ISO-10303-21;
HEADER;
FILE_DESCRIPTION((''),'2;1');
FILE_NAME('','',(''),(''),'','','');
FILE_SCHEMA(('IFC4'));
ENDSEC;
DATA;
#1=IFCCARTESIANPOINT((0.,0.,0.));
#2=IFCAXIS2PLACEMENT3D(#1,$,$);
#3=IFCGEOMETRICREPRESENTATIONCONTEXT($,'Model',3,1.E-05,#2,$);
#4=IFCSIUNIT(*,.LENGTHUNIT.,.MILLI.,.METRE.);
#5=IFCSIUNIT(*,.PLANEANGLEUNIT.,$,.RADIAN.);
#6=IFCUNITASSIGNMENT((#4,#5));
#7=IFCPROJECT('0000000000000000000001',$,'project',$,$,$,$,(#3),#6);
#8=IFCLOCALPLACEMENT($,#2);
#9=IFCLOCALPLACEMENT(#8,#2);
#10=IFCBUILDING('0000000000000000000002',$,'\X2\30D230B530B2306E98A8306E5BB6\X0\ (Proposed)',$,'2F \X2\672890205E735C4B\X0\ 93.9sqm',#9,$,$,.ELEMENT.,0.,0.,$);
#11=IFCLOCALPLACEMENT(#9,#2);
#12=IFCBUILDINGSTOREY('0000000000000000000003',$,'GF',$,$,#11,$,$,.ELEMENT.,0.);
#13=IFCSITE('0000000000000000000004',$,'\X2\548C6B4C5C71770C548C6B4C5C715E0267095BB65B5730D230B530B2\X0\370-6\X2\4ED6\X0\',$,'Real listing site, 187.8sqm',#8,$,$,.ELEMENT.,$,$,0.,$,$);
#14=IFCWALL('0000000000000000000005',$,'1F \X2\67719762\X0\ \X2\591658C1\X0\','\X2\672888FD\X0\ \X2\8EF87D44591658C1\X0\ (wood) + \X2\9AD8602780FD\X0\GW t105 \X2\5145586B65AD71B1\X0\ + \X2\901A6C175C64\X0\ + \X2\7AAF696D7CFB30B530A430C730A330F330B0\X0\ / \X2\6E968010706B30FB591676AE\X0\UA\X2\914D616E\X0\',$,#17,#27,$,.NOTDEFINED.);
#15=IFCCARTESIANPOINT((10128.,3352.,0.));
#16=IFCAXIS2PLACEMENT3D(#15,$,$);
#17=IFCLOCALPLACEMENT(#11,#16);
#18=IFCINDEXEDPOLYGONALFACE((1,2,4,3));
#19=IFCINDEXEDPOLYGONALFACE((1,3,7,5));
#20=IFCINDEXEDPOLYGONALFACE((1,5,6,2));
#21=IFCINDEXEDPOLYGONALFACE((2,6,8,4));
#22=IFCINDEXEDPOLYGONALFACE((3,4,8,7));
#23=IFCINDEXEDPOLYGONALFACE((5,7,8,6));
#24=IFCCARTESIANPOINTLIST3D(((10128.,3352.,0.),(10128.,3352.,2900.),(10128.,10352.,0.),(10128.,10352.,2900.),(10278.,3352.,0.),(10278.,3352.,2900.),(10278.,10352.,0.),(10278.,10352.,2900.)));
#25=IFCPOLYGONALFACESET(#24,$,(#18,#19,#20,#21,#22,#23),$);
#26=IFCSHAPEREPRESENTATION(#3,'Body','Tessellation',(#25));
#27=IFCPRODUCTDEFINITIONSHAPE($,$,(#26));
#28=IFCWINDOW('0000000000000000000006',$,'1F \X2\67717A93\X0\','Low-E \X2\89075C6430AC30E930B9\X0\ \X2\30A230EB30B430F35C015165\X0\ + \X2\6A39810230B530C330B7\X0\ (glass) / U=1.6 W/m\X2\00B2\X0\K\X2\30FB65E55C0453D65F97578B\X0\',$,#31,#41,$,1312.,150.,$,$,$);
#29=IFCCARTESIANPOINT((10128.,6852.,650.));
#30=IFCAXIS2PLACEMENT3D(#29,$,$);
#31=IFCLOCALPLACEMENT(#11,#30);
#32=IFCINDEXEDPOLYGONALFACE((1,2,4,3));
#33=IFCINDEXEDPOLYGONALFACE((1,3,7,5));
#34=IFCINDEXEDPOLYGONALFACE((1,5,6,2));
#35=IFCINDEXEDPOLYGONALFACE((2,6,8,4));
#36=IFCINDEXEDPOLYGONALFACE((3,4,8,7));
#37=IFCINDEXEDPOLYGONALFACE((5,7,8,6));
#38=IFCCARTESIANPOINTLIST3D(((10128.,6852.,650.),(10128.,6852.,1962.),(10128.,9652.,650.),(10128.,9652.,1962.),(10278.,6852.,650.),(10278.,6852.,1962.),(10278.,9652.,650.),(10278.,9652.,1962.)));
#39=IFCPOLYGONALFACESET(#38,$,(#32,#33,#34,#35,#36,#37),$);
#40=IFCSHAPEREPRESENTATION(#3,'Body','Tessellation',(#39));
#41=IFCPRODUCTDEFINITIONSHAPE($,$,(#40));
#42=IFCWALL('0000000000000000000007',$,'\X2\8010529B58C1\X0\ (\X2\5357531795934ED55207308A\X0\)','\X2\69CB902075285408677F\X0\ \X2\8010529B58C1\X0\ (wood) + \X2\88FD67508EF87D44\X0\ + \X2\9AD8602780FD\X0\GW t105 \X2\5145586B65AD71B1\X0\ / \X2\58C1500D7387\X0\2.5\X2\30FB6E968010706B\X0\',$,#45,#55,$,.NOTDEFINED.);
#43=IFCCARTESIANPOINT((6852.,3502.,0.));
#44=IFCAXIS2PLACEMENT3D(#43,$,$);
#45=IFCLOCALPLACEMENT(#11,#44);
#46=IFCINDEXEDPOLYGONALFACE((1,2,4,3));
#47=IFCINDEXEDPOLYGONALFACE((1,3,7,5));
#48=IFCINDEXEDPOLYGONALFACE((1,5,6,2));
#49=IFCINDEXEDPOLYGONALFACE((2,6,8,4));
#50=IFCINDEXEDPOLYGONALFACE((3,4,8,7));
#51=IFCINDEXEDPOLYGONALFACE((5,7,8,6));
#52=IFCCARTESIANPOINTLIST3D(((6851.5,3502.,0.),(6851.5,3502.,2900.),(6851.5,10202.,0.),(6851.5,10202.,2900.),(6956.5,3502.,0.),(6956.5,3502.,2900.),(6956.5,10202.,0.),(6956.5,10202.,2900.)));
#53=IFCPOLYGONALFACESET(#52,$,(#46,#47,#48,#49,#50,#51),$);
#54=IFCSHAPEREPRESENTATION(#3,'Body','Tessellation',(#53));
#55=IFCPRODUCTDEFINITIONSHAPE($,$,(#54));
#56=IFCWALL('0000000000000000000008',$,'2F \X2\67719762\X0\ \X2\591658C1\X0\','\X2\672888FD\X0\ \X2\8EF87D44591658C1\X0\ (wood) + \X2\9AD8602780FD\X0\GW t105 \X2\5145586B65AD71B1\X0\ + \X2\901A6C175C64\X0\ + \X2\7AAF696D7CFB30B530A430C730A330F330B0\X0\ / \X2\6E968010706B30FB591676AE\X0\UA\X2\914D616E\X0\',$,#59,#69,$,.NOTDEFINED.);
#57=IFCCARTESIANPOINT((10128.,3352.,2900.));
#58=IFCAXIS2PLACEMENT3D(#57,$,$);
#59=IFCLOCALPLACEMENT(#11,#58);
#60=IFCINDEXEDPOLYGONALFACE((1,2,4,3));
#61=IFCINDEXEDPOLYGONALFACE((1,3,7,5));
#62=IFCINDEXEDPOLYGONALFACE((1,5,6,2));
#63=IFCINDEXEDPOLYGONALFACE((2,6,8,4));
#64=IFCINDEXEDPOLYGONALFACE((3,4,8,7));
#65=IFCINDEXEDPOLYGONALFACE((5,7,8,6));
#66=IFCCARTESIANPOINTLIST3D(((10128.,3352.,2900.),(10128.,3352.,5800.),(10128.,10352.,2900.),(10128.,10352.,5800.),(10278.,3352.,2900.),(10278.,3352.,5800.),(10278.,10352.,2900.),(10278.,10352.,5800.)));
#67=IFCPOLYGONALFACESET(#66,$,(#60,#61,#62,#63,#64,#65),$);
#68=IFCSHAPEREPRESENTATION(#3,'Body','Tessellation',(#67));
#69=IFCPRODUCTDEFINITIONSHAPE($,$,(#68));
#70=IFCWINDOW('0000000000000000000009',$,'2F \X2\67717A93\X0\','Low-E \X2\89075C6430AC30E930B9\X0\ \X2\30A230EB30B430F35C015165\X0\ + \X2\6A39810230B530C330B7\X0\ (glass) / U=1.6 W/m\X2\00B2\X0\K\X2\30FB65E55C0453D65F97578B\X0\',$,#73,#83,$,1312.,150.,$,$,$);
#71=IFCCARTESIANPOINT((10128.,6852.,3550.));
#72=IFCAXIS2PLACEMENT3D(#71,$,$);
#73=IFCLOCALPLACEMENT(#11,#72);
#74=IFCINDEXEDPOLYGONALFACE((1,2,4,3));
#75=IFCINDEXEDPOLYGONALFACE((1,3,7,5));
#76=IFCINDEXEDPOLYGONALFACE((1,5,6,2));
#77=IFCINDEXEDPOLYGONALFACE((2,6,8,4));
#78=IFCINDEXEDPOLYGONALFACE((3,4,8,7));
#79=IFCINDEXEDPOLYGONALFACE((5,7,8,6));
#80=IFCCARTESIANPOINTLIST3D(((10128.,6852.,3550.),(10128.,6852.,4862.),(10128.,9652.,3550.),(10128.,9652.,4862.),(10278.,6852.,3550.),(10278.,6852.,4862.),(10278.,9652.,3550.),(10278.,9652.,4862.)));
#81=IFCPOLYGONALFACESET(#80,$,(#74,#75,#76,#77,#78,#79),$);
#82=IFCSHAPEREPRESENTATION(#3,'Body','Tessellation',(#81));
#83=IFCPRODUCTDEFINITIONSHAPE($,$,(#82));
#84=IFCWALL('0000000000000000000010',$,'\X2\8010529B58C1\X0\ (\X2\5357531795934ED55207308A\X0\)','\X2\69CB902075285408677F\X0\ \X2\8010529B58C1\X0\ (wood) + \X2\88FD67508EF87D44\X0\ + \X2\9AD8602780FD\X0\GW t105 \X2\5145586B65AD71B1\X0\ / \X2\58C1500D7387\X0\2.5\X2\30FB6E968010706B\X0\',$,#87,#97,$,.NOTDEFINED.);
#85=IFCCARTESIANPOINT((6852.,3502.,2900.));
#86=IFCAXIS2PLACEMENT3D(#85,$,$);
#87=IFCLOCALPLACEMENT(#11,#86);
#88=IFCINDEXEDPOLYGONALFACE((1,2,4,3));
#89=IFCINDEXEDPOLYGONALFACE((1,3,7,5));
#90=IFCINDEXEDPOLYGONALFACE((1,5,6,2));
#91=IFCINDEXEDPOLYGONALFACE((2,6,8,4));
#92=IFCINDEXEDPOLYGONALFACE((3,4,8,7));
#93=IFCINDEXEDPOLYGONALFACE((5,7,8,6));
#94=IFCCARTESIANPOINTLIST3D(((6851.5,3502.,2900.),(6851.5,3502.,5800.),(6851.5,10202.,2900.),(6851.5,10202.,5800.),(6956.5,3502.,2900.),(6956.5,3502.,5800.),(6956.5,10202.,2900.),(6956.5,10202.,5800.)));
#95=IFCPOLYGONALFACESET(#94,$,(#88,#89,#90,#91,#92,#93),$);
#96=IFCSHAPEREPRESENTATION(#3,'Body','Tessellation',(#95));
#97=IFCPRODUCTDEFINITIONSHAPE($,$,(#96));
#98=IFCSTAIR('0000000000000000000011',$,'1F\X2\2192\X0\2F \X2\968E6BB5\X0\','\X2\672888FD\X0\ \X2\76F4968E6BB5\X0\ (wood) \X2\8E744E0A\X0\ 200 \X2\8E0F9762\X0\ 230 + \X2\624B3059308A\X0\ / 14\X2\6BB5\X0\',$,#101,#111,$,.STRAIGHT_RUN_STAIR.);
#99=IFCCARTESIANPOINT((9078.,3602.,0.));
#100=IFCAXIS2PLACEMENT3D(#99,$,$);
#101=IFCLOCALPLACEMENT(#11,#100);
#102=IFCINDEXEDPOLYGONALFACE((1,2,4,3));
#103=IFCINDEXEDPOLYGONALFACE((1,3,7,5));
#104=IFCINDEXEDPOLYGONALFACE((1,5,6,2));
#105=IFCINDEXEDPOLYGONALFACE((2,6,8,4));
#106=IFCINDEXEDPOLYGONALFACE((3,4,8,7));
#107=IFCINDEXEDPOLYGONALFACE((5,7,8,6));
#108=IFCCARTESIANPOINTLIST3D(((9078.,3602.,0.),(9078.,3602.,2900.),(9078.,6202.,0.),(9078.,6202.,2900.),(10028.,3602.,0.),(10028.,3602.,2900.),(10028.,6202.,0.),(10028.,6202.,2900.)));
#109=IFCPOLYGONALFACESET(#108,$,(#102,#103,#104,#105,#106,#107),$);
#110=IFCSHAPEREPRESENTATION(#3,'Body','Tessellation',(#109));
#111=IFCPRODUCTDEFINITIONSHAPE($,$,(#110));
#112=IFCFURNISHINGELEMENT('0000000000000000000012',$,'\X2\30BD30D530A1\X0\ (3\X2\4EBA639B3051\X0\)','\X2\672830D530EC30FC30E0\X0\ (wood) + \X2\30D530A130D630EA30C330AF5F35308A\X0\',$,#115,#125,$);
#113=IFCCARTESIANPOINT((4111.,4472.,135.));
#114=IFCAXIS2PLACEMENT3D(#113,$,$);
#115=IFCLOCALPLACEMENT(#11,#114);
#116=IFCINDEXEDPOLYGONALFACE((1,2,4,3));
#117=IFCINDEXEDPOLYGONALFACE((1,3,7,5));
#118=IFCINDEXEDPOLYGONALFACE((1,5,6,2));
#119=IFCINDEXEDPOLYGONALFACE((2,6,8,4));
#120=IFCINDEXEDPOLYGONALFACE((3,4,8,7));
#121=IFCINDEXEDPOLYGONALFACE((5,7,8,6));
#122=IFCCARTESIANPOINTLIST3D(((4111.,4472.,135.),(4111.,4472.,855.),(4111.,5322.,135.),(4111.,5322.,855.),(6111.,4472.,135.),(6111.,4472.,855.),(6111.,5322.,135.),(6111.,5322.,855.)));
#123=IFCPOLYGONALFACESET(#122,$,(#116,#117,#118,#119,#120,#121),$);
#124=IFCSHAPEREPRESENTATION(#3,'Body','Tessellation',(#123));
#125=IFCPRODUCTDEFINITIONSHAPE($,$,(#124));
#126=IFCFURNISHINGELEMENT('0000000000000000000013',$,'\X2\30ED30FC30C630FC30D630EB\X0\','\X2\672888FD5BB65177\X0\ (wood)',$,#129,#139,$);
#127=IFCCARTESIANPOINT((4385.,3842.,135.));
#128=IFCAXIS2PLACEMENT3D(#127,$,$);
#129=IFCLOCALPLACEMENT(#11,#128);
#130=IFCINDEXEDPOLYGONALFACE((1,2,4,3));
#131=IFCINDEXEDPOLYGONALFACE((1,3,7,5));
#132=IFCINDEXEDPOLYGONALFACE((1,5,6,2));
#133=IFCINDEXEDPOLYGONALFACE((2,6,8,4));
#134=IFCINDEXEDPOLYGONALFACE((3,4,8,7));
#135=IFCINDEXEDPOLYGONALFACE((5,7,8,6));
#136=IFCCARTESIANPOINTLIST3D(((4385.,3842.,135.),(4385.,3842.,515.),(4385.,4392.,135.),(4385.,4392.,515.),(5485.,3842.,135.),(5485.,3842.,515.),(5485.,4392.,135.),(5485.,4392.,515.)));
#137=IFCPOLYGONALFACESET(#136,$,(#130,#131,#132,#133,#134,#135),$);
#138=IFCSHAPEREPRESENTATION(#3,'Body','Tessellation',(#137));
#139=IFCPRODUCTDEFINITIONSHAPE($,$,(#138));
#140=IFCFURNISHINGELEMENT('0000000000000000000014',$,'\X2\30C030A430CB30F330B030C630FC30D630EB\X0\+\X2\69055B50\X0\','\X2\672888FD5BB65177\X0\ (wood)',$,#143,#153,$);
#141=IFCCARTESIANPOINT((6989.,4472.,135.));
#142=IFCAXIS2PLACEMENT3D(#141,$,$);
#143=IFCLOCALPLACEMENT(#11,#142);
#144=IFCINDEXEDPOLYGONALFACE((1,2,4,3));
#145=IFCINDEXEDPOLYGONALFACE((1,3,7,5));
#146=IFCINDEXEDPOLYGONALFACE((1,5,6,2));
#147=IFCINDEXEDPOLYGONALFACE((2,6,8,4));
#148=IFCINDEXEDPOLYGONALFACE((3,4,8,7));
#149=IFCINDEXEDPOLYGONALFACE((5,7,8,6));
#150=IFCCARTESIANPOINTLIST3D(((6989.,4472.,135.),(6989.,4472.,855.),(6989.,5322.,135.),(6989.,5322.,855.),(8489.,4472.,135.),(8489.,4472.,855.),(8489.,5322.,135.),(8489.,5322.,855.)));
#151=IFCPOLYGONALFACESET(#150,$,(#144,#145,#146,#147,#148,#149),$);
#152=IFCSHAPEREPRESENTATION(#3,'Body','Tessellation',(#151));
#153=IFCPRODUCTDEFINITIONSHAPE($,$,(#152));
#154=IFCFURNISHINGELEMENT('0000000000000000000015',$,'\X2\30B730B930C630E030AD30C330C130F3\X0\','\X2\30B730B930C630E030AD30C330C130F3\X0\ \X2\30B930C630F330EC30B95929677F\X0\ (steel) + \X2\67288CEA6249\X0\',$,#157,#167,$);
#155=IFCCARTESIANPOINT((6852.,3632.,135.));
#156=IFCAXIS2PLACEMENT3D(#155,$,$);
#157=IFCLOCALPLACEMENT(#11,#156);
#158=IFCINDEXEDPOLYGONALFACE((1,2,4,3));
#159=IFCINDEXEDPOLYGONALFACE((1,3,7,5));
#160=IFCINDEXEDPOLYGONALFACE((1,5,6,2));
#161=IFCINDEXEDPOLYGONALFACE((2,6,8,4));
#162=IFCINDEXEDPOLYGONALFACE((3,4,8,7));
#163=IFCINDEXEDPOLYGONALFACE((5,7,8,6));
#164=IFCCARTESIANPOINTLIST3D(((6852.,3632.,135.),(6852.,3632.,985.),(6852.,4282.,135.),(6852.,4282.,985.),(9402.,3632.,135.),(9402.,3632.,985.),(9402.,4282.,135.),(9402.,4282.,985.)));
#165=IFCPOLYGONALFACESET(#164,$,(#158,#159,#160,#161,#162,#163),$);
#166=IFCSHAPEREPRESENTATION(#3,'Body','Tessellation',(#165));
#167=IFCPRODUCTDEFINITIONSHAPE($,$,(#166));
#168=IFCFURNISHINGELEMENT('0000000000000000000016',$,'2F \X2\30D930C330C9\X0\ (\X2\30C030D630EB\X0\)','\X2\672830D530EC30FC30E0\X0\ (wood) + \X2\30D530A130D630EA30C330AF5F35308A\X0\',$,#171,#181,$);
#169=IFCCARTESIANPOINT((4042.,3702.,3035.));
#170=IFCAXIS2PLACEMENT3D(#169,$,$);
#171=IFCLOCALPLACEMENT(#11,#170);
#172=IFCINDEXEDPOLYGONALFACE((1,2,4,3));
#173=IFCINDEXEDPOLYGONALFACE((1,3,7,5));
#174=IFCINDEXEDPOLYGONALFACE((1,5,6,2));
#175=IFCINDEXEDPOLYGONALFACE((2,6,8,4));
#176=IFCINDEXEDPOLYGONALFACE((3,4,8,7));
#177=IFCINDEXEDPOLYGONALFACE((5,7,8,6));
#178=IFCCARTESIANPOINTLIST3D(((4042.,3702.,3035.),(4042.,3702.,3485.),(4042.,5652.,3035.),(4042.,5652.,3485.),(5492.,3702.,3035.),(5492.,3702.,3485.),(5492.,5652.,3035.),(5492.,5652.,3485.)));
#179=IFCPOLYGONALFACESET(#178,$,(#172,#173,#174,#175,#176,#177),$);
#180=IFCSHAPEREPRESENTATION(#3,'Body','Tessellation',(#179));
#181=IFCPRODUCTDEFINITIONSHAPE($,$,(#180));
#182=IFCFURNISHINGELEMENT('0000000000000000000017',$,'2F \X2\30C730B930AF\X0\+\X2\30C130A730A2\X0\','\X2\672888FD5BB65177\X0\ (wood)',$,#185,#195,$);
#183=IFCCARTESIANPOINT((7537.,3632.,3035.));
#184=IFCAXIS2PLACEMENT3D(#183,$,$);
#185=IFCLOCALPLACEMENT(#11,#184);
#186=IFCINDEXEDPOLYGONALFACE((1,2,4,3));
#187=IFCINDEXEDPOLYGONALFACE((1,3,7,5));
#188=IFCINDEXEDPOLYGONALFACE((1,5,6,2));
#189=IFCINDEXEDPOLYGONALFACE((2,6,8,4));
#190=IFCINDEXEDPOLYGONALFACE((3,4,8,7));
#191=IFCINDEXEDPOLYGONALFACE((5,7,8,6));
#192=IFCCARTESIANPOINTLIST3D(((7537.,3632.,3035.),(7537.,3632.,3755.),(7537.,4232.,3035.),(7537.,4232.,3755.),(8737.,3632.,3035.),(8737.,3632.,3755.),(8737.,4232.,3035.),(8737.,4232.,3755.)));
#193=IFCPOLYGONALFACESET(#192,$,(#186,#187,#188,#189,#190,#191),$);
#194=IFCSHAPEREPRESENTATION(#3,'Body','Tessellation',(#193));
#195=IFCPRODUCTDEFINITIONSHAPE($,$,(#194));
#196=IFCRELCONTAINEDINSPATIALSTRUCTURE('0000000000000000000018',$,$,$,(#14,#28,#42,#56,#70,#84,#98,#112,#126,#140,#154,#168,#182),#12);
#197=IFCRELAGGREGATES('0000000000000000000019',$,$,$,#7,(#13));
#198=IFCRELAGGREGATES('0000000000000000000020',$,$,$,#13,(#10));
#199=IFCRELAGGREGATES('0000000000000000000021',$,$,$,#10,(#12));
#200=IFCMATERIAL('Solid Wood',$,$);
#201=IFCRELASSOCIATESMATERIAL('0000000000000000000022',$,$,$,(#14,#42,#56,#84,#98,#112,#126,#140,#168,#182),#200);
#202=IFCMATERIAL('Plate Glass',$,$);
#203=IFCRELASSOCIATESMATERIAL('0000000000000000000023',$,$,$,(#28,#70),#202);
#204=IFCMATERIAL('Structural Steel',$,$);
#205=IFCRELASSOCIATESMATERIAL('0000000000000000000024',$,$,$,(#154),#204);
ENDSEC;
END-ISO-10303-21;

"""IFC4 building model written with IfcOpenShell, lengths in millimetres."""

from ifc_helpers import new_model, si_unit, frame, frame_2d, origin, place, context, project, spatial, rectangle, extrude, material, element, fill, save


model = new_model("IFC4")

# Units and contexts
model_context = context("Model", 3, precision=1e-05, world=origin())
ifc_project = project(units=[si_unit("LENGTHUNIT", "METRE", prefix="MILLI"), si_unit("PLANEANGLEUNIT", "RADIAN")], contexts=[model_context])

# Site, building, storey
site_placement = place(None, origin())
site = spatial("IfcSite", under=ifc_project, at=site_placement, Name="和歌山県和歌山市有家字ヒサゲ370-6他", ObjectType="Real listing site, 187.8sqm", CompositionType="ELEMENT", RefElevation=0.0)
building_placement = place(site_placement, origin())
building = spatial("IfcBuilding", under=site, at=building_placement, Name="ヒサゲの風の家 (Proposed)", ObjectType="2F 木造平屋 93.9sqm", CompositionType="ELEMENT", ElevationOfRefHeight=0.0, ElevationOfTerrain=0.0)
storey_placement = place(building_placement, origin())
storey = spatial("IfcBuildingStorey", under=building, at=storey_placement, Name="GF", CompositionType="ELEMENT", Elevation=0.0)

# Wall, opening, window
ifc_material_1 = material(Name="Solid Wood")
wall_1_placement = place(storey_placement, frame((10128.0, 3352.0, 0.0)))
wall_1 = element("IfcWall", 1, at=wall_1_placement, inside=storey, material=ifc_material_1, Name="1F 東面 外壁", Description="木製 軸組外壁 (wood) + 高性能GW t105 充填断熱 + 通気層 + 窯業系サイディング / 準耐火・外皮UA配慮", PredefinedType="NOTDEFINED", context=model_context, shape_type="SweptSolid", body=[
    extrude(rectangle(XDim=150.0, YDim=7000.0, at=frame_2d((75.0, 3500.0))), frame((10128.0, 3352.0, 0.0)), (0.0, 0.0, 1.0), 2900.0),
])
opening_1_placement = place(storey_placement, frame((10128.0, 6852.0, 650.0)))
opening_1 = element("IfcOpeningElement", 2, at=opening_1_placement, cuts=wall_1, PredefinedType="NOTDEFINED", context=model_context, shape_type="SweptSolid", body=[
    extrude(rectangle(XDim=150.0, YDim=2800.0, at=frame_2d((75.0, 1400.0))), frame((10128.0, 6852.0, 650.0)), (0.0, 0.0, 1.0), 1312.0),
])
ifc_material_2 = material(Name="Plate Glass")
window_1_placement = place(storey_placement, frame((10128.0, 6852.0, 650.0)))
window_1 = element("IfcWindow", 3, at=window_1_placement, inside=storey, material=ifc_material_2, Name="1F 東窓", Description="Low-E 複層ガラス アルゴン封入 + 樹脂サッシ (glass) / U=1.6 W/m²K・日射取得型", OverallHeight=1312.0, OverallWidth=150.0, context=model_context, shape_type="SweptSolid", body=[
    extrude(rectangle(XDim=150.0, YDim=2800.0, at=frame_2d((75.0, 1400.0))), frame((10128.0, 6852.0, 650.0)), (0.0, 0.0, 1.0), 1312.0),
])
fill(opening_1, window_1)

# Wall
wall_2_placement = place(storey_placement, frame((6852.0, 3502.0, 0.0)))
element("IfcWall", 4, at=wall_2_placement, inside=storey, material=ifc_material_1, Name="耐力壁 (南北間仕切り)", Description="構造用合板 耐力壁 (wood) + 製材軸組 + 高性能GW t105 充填断熱 / 壁倍率2.5・準耐火", PredefinedType="NOTDEFINED", context=model_context, shape_type="SweptSolid", body=[
    extrude(rectangle(XDim=105.0, YDim=6700.0, at=frame_2d((52.0, 3350.0))), frame((6852.0, 3502.0, 0.0)), (0.0, 0.0, 1.0), 2900.0),
])

# Wall, opening, window
wall_3_placement = place(storey_placement, frame((10128.0, 3352.0, 2900.0)))
wall_3 = element("IfcWall", 5, at=wall_3_placement, inside=storey, material=ifc_material_1, Name="2F 東面 外壁", Description="木製 軸組外壁 (wood) + 高性能GW t105 充填断熱 + 通気層 + 窯業系サイディング / 準耐火・外皮UA配慮", PredefinedType="NOTDEFINED", context=model_context, shape_type="SweptSolid", body=[
    extrude(rectangle(XDim=150.0, YDim=7000.0, at=frame_2d((75.0, 3500.0))), frame((10128.0, 3352.0, 2900.0)), (0.0, 0.0, 1.0), 2900.0),
])
opening_2_placement = place(storey_placement, frame((10128.0, 6852.0, 3550.0)))
opening_2 = element("IfcOpeningElement", 6, at=opening_2_placement, cuts=wall_3, PredefinedType="NOTDEFINED", context=model_context, shape_type="SweptSolid", body=[
    extrude(rectangle(XDim=150.0, YDim=2800.0, at=frame_2d((75.0, 1400.0))), frame((10128.0, 6852.0, 3550.0)), (0.0, 0.0, 1.0), 1312.0),
])
window_2_placement = place(storey_placement, frame((10128.0, 6852.0, 3550.0)))
window_2 = element("IfcWindow", 7, at=window_2_placement, inside=storey, material=ifc_material_2, Name="2F 東窓", Description="Low-E 複層ガラス アルゴン封入 + 樹脂サッシ (glass) / U=1.6 W/m²K・日射取得型", OverallHeight=1312.0, OverallWidth=150.0, context=model_context, shape_type="SweptSolid", body=[
    extrude(rectangle(XDim=150.0, YDim=2800.0, at=frame_2d((75.0, 1400.0))), frame((10128.0, 6852.0, 3550.0)), (0.0, 0.0, 1.0), 1312.0),
])
fill(opening_2, window_2)

# Wall
wall_4_placement = place(storey_placement, frame((6852.0, 3502.0, 2900.0)))
element("IfcWall", 8, at=wall_4_placement, inside=storey, material=ifc_material_1, Name="耐力壁 (南北間仕切り)", Description="構造用合板 耐力壁 (wood) + 製材軸組 + 高性能GW t105 充填断熱 / 壁倍率2.5・準耐火", PredefinedType="NOTDEFINED", context=model_context, shape_type="SweptSolid", body=[
    extrude(rectangle(XDim=105.0, YDim=6700.0, at=frame_2d((52.0, 3350.0))), frame((6852.0, 3502.0, 2900.0)), (0.0, 0.0, 1.0), 2900.0),
])

# Stair
stair_placement = place(storey_placement, frame((9078.0, 3602.0, 0.0)))
element("IfcStair", 9, at=stair_placement, inside=storey, material=ifc_material_1, Name="1F→2F 階段", Description="木製 直階段 (wood) 蹴上 200 踏面 230 + 手すり / 14段", PredefinedType="STRAIGHT_RUN_STAIR", context=model_context, shape_type="SweptSolid", body=[
    extrude(rectangle(XDim=950.0, YDim=2600.0, at=frame_2d((475.0, 1300.0))), frame((9078.0, 3602.0, 0.0)), (0.0, 0.0, 1.0), 2900.0),
])

# Furnishing elements
furnishing_1_placement = place(storey_placement, frame((4111.0, 4472.0, 135.0)))
element("IfcFurnishingElement", 10, at=furnishing_1_placement, inside=storey, material=ifc_material_1, Name="ソファ (3人掛け)", Description="木フレーム (wood) + ファブリック張り", context=model_context, shape_type="SweptSolid", body=[
    extrude(rectangle(XDim=2000.0, YDim=850.0, at=frame_2d((1000.0, 425.0))), frame((4111.0, 4472.0, 135.0)), (0.0, 0.0, 1.0), 720.0),
])
furnishing_2_placement = place(storey_placement, frame((4385.0, 3842.0, 135.0)))
element("IfcFurnishingElement", 11, at=furnishing_2_placement, inside=storey, material=ifc_material_1, Name="ローテーブル", Description="木製家具 (wood)", context=model_context, shape_type="SweptSolid", body=[
    extrude(rectangle(XDim=1100.0, YDim=550.0, at=frame_2d((550.0, 275.0))), frame((4385.0, 3842.0, 135.0)), (0.0, 0.0, 1.0), 380.0),
])
furnishing_3_placement = place(storey_placement, frame((6989.0, 4472.0, 135.0)))
element("IfcFurnishingElement", 12, at=furnishing_3_placement, inside=storey, material=ifc_material_1, Name="ダイニングテーブル+椅子", Description="木製家具 (wood)", context=model_context, shape_type="SweptSolid", body=[
    extrude(rectangle(XDim=1500.0, YDim=850.0, at=frame_2d((750.0, 425.0))), frame((6989.0, 4472.0, 135.0)), (0.0, 0.0, 1.0), 720.0),
])
ifc_material_3 = material(Name="Structural Steel")
furnishing_4_placement = place(storey_placement, frame((6852.0, 3632.0, 135.0)))
element("IfcFurnishingElement", 13, at=furnishing_4_placement, inside=storey, material=ifc_material_3, Name="システムキッチン", Description="システムキッチン ステンレス天板 (steel) + 木質扉", context=model_context, shape_type="SweptSolid", body=[
    extrude(rectangle(XDim=2550.0, YDim=650.0, at=frame_2d((1275.0, 325.0))), frame((6852.0, 3632.0, 135.0)), (0.0, 0.0, 1.0), 850.0),
])
furnishing_5_placement = place(storey_placement, frame((4042.0, 3702.0, 3035.0)))
element("IfcFurnishingElement", 14, at=furnishing_5_placement, inside=storey, material=ifc_material_1, Name="2F ベッド (ダブル)", Description="木フレーム (wood) + ファブリック張り", context=model_context, shape_type="SweptSolid", body=[
    extrude(rectangle(XDim=1450.0, YDim=1950.0, at=frame_2d((725.0, 975.0))), frame((4042.0, 3702.0, 3035.0)), (0.0, 0.0, 1.0), 450.0),
])
furnishing_6_placement = place(storey_placement, frame((7537.0, 3632.0, 3035.0)))
element("IfcFurnishingElement", 15, at=furnishing_6_placement, inside=storey, material=ifc_material_1, Name="2F デスク+チェア", Description="木製家具 (wood)", context=model_context, shape_type="SweptSolid", body=[
    extrude(rectangle(XDim=1200.0, YDim=600.0, at=frame_2d((600.0, 300.0))), frame((7537.0, 3632.0, 3035.0)), (0.0, 0.0, 1.0), 720.0),
])

save(model, "model.ifc")
